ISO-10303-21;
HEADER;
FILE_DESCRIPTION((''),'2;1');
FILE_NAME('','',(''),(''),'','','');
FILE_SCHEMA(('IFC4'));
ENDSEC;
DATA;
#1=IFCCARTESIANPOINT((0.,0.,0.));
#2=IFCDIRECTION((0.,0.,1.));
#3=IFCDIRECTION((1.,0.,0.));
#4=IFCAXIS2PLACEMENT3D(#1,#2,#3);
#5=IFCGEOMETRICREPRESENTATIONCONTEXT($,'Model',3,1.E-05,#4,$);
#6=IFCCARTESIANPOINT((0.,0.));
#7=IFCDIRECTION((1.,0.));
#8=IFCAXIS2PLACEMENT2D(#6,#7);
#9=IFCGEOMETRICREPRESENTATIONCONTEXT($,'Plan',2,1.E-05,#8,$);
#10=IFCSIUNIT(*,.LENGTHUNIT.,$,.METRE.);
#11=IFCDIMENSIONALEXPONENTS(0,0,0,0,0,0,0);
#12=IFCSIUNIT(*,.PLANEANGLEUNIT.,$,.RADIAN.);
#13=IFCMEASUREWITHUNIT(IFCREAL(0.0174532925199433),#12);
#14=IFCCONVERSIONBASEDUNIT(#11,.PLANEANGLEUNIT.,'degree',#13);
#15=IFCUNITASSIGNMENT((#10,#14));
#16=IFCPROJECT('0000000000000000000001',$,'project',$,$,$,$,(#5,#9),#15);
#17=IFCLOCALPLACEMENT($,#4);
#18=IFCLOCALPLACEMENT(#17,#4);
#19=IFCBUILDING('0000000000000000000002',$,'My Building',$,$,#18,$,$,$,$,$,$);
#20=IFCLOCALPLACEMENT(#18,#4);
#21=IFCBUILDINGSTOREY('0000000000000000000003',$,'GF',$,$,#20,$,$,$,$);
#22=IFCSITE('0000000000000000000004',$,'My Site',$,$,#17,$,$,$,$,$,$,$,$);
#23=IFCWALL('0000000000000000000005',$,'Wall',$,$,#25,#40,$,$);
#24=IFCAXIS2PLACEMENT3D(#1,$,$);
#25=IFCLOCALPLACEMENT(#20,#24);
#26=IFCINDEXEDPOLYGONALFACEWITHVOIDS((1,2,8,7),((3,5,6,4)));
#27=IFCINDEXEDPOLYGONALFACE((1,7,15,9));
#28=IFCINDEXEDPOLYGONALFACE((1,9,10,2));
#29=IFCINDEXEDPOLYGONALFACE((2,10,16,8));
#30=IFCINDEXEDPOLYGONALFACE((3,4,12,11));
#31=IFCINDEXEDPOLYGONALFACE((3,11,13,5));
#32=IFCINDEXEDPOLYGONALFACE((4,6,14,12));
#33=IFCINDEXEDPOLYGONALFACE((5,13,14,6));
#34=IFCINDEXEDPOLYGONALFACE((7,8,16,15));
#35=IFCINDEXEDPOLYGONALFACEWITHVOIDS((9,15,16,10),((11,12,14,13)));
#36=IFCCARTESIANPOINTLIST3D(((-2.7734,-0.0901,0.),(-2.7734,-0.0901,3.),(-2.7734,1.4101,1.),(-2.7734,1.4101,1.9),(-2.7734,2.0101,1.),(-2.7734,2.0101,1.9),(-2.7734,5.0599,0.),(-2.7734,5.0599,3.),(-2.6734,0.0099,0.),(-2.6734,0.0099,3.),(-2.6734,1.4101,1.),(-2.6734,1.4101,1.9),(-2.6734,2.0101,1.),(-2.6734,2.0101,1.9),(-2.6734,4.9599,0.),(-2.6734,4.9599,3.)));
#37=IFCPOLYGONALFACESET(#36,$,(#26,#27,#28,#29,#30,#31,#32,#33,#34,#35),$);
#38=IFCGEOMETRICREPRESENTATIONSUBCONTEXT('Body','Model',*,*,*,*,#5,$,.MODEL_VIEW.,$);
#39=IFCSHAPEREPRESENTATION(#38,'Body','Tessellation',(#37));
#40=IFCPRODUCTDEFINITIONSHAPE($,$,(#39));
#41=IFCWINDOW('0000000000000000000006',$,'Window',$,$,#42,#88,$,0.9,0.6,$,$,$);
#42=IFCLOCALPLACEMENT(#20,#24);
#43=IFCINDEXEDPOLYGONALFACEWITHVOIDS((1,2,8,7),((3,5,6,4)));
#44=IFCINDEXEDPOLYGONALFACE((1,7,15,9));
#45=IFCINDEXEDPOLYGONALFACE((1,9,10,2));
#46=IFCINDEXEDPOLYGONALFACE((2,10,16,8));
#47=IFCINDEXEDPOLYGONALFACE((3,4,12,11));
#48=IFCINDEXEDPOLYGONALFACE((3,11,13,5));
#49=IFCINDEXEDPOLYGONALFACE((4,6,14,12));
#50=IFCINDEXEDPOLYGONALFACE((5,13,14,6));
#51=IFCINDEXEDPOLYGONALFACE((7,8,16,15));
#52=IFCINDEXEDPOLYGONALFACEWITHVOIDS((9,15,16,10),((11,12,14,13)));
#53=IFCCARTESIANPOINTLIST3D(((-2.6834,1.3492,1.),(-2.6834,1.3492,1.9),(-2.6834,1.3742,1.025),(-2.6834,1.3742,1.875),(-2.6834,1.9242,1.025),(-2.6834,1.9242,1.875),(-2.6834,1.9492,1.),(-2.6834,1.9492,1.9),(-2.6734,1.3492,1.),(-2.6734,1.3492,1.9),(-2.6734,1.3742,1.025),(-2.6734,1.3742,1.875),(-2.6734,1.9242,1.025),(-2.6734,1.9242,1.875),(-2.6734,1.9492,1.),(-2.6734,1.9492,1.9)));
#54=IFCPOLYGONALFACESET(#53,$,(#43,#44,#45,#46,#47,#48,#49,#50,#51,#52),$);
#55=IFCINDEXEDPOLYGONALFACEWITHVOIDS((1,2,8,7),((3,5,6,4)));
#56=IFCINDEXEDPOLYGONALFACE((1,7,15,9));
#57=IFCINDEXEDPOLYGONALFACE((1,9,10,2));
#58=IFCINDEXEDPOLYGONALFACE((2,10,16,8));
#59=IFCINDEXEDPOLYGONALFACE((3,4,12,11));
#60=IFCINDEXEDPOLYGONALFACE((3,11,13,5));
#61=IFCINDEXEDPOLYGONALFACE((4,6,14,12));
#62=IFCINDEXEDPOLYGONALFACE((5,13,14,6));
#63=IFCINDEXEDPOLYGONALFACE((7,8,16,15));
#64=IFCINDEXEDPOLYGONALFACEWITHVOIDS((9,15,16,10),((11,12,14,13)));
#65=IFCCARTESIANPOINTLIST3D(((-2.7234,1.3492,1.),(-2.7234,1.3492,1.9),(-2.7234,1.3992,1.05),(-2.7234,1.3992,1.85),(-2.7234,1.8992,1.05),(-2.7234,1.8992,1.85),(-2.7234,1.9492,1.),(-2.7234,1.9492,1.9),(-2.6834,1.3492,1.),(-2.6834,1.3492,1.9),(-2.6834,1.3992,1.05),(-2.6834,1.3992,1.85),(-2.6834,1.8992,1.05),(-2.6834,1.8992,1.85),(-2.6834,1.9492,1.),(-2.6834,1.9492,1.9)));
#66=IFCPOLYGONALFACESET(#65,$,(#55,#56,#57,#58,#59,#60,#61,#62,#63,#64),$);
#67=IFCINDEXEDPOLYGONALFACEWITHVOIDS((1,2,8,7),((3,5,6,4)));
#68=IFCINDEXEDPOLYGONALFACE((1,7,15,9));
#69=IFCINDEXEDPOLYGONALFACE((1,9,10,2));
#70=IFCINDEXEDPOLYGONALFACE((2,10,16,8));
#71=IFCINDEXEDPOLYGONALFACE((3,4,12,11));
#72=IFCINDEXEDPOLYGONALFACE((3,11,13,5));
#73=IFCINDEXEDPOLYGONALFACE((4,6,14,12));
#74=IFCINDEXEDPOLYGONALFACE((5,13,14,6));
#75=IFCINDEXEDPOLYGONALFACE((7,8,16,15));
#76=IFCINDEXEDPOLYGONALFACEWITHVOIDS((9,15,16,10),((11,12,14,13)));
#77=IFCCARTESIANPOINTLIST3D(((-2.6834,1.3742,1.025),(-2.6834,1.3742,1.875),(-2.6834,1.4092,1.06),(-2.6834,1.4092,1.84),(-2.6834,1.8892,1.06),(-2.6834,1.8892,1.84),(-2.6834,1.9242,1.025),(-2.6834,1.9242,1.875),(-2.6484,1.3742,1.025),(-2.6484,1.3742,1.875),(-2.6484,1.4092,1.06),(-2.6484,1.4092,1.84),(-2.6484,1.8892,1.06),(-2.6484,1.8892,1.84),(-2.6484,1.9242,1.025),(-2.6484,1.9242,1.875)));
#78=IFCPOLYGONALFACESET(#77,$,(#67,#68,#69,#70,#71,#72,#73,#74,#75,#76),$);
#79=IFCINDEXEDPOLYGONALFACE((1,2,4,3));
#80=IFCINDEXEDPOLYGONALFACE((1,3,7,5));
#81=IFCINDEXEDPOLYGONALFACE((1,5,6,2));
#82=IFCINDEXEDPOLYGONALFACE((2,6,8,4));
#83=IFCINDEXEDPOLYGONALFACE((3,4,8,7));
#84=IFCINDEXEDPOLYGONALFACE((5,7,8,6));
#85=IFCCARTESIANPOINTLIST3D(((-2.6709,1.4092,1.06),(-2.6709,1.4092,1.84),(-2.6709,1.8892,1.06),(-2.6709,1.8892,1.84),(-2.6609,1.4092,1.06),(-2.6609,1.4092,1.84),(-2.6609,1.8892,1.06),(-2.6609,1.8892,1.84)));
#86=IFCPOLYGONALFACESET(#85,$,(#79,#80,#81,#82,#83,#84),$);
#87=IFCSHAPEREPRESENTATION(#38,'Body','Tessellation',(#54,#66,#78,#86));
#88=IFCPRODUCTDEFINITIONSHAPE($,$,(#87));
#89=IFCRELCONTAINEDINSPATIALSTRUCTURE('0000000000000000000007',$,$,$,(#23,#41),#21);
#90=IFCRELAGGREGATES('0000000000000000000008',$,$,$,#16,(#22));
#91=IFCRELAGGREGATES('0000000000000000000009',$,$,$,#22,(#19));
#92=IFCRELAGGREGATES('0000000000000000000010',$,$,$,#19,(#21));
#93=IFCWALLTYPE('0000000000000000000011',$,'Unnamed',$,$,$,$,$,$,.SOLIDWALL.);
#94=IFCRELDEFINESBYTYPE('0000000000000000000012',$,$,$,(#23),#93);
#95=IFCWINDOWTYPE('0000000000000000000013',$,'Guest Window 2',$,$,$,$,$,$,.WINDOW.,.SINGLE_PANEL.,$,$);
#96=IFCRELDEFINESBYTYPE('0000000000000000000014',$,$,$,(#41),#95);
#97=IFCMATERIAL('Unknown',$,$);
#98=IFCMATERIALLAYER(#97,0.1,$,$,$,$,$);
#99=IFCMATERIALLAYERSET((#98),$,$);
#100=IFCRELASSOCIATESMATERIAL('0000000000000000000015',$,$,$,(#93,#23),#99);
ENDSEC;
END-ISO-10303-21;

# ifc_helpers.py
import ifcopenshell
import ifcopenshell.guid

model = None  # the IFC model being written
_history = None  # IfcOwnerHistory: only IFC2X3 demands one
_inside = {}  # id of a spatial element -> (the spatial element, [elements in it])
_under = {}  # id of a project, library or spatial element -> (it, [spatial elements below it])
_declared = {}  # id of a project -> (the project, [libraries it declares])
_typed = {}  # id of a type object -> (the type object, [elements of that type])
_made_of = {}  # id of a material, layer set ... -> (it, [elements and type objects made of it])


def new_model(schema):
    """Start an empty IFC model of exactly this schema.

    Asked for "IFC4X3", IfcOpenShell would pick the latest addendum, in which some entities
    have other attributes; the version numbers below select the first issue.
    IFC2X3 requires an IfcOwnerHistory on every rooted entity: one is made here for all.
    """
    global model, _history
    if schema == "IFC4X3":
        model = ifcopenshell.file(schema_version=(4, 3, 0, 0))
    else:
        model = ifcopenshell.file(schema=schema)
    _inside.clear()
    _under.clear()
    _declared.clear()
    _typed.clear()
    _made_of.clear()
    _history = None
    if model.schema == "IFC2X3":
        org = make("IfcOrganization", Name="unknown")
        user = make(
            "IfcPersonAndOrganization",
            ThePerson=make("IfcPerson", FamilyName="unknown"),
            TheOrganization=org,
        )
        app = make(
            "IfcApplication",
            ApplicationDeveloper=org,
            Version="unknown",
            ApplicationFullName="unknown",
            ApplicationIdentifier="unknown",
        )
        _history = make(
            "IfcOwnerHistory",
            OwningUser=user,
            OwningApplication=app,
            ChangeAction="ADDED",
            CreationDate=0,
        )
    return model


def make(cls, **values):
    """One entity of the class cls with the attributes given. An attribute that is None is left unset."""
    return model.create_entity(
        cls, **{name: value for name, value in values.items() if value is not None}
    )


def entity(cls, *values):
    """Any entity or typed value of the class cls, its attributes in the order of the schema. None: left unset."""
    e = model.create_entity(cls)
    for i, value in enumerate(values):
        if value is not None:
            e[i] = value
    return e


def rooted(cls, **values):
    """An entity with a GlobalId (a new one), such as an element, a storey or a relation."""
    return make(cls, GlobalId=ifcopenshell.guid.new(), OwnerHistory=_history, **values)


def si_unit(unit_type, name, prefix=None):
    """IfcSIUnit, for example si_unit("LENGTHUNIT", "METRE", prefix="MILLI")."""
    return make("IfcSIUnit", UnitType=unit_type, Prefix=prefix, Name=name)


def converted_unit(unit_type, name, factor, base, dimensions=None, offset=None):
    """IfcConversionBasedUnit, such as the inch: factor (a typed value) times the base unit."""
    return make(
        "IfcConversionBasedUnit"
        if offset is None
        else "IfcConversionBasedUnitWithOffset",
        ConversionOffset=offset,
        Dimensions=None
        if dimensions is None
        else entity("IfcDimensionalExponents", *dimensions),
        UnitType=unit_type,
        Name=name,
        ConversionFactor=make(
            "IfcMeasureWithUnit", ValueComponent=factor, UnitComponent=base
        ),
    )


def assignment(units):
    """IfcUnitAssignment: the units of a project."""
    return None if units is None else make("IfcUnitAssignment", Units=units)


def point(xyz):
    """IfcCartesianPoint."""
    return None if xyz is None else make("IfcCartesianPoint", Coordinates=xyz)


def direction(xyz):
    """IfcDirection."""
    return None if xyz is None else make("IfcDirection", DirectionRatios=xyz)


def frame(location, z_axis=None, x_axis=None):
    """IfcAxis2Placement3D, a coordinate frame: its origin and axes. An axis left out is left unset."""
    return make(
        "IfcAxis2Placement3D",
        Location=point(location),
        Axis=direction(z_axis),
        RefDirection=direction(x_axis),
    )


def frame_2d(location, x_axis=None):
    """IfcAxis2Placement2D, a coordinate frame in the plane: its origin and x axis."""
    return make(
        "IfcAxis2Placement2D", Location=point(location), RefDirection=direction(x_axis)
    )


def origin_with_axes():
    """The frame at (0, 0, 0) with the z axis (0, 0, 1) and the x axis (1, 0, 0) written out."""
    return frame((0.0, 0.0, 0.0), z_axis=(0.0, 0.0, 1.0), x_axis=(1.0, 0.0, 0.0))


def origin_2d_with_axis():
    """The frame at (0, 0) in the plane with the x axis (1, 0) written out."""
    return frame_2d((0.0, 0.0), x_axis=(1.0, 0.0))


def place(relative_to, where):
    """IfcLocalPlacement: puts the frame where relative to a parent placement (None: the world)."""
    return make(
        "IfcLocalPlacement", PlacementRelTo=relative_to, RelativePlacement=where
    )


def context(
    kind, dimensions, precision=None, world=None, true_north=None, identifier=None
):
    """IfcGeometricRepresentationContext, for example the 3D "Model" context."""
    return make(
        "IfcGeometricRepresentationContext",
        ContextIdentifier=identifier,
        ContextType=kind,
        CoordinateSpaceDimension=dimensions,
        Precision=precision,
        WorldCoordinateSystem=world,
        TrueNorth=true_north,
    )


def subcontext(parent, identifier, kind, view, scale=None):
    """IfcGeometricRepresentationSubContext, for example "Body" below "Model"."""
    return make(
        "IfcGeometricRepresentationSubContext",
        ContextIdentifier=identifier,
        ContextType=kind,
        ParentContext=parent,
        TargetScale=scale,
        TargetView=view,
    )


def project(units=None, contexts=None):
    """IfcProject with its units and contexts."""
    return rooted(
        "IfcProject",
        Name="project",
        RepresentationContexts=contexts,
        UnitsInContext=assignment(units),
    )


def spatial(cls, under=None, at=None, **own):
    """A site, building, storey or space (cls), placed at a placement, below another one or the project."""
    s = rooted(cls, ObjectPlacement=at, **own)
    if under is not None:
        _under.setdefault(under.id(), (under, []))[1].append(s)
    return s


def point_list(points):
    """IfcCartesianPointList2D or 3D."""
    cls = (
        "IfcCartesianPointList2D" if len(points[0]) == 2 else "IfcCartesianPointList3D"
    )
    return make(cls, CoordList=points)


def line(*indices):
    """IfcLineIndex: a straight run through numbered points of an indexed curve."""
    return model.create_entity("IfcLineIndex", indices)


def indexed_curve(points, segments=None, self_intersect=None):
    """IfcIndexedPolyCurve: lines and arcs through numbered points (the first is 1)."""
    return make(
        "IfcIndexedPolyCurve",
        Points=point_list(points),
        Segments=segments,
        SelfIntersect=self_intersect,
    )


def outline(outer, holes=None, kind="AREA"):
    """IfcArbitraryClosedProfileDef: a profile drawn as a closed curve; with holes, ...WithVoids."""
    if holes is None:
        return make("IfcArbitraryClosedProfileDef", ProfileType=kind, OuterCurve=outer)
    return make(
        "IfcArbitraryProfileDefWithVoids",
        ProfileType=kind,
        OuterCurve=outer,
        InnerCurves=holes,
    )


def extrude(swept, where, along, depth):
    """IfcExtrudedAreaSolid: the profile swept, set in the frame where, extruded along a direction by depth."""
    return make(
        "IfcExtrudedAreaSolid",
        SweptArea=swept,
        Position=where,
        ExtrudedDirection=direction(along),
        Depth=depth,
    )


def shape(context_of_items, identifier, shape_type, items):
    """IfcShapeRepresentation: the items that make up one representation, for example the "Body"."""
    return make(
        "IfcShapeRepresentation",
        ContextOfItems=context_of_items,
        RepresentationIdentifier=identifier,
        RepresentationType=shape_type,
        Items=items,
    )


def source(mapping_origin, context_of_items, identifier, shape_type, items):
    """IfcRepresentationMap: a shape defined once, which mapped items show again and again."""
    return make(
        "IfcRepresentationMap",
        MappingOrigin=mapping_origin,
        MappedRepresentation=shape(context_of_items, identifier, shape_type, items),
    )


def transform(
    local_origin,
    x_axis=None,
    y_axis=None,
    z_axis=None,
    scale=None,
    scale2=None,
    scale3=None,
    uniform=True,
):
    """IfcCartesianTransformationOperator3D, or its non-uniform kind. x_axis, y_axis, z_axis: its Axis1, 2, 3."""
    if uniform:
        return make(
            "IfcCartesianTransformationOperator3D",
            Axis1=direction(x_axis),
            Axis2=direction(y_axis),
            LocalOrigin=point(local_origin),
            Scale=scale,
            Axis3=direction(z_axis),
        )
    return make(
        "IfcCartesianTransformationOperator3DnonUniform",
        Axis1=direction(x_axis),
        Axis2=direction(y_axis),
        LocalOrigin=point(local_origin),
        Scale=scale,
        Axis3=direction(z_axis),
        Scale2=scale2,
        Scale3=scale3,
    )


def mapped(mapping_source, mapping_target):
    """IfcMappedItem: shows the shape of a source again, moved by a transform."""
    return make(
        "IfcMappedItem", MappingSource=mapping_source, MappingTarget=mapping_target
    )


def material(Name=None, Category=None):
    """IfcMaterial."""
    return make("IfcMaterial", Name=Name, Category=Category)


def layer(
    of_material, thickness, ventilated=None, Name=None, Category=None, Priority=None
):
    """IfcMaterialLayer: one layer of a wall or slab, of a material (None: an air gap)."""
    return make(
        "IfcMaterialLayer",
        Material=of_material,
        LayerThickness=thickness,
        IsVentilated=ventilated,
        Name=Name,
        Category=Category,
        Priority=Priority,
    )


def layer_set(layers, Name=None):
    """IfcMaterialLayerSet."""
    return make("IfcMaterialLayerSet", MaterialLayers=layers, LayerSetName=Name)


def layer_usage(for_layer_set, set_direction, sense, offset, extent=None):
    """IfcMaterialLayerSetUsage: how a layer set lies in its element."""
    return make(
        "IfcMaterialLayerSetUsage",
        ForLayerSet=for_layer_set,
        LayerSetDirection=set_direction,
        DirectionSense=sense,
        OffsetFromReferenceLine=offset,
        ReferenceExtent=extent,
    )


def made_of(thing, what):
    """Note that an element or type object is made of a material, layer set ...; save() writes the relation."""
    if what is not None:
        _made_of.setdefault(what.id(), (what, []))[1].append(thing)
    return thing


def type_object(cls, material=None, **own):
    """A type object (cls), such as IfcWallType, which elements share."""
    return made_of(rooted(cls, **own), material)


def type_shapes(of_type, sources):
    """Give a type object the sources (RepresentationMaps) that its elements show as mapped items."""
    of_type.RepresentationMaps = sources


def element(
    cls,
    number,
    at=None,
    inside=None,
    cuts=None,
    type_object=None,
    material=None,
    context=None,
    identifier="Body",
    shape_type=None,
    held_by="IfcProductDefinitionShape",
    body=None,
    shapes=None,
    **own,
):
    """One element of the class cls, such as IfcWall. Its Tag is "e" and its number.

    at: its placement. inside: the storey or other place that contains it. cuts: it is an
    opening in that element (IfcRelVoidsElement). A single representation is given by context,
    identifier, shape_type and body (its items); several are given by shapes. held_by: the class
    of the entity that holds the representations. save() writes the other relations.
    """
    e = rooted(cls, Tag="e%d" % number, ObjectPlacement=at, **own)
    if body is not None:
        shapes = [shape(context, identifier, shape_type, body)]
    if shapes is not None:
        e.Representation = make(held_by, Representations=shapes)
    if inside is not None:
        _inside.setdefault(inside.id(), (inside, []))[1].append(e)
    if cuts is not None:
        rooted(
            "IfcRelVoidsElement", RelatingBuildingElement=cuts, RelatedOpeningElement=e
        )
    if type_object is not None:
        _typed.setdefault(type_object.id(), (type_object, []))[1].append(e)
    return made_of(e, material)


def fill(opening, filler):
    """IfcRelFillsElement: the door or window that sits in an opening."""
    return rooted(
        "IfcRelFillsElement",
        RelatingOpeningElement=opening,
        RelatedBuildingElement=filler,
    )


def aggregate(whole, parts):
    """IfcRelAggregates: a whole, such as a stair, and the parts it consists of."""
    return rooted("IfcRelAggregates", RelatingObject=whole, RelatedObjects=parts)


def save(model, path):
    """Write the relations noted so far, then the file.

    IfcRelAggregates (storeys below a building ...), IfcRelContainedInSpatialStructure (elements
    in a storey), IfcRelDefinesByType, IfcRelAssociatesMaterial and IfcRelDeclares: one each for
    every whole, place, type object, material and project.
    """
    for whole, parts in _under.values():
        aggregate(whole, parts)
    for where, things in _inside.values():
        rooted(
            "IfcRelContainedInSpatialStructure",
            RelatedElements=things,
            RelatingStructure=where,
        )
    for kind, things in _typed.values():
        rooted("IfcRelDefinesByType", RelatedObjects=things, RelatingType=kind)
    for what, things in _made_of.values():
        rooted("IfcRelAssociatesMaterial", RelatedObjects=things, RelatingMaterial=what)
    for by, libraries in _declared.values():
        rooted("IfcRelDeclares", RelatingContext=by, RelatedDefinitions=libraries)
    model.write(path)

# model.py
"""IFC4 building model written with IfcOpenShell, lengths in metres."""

from ifc_helpers import new_model, entity, si_unit, converted_unit, frame, origin_with_axes, origin_2d_with_axis, place, context, subcontext, project, spatial, line, indexed_curve, outline, extrude, shape, source, transform, mapped, material, layer, layer_set, layer_usage, type_object, type_shapes, element, fill, save


model = new_model("IFC4")

# Units and contexts
model_context = context("Model", 3, precision=1e-05, world=origin_with_axes())
plan_context = context("Plan", 2, precision=1e-05, world=origin_2d_with_axis())
body_context_1 = subcontext(model_context, "Body", "Model", "MODEL_VIEW")
body_context_2 = subcontext(plan_context, "Body", "Plan", "PLAN_VIEW")
ifc_project = project(units=[si_unit("LENGTHUNIT", "METRE"), converted_unit("PLANEANGLEUNIT", "degree", entity("IfcReal", 0.0174532925199433), si_unit("PLANEANGLEUNIT", "RADIAN"), dimensions=[0, 0, 0, 0, 0, 0, 0])], contexts=[model_context, plan_context])

# Site, building, storey
site_placement = place(None, origin_with_axes())
site = spatial("IfcSite", under=ifc_project, at=site_placement, Name="My Site")
building_placement = place(site_placement, origin_with_axes())
building = spatial("IfcBuilding", under=site, at=building_placement, Name="My Building")
storey_placement = place(building_placement, origin_with_axes())
storey = spatial("IfcBuildingStorey", under=building, at=storey_placement, Name="GF")

# Shared definitions
ifc_material = material(Name="Unknown")

# Shared definitions
ifc_layer_1 = layer(ifc_material, 0.1)
ifc_layer_set_1 = layer_set([ifc_layer_1])
wall_type = type_object("IfcWallType", Name="Unnamed", PredefinedType="SOLIDWALL", material=ifc_layer_set_1)

# Wall, opening, window
ifc_layer_usage_1 = layer_usage(ifc_layer_set_1, "AXIS2", "POSITIVE", 0.0)
wall_1_placement = place(storey_placement, frame((-2.7734, 5.0599, 0.0), z_axis=(0.0, 0.0, 1.0), x_axis=(0.0, -1.0, 0.0)))
wall_1 = element("IfcWall", 1, at=wall_1_placement, inside=storey, type_object=wall_type, material=ifc_layer_usage_1, Name="Wall", context=body_context_1, shape_type="SweptSolid", body=[
    extrude(outline(indexed_curve([(0.0, 0.0), (0.1, 0.1), (5.05, 0.1), (5.15, 0.0)], segments=[line(1, 2, 3, 4, 1)])), origin_with_axes(), (0.0, 0.0, 1.0), 3.0),
])
shared_shape_1 = source(origin_with_axes(), body_context_1, "Body", "SweptSolid", [
    extrude(outline(indexed_curve([(0.0, 0.0), (0.6, 0.0), (0.6, 0.9), (0.0, 0.9)], segments=[line(1, 2, 3, 4, 1)])), frame((0.0, -0.6, 0.0), z_axis=(0.0, -1.0, 0.0), x_axis=(1.0, 0.0, 0.0)), (0.0, 0.0, -1.0), 1.2),
])
opening_1_placement = place(wall_1_placement, frame((3.0498, 0.0, 1.0), z_axis=(0.0, 0.0, 1.0), x_axis=(1.0, 0.0, 0.0)))
opening_1 = element("IfcOpeningElement", 2, at=opening_1_placement, cuts=wall_1, PredefinedType="OPENING", context=body_context_1, shape_type="MappedRepresentation", body=[
    mapped(shared_shape_1, transform((0.0, 0.0, 0.0), x_axis=(1.0, 0.0, 0.0), y_axis=(0.0, 1.0, 0.0), z_axis=(0.0, 0.0, 1.0), scale=1.0)),
])
window_type_1 = type_object("IfcWindowType", Name="Guest Window 2", PartitioningType="SINGLE_PANEL", PredefinedType="WINDOW")
shared_shape_2 = source(origin_with_axes(), body_context_1, "Body", "SweptSolid", [
    extrude(outline(indexed_curve([(0.0, 0.0), (0.6, 0.0), (0.6, 0.9), (0.0, 0.9)], segments=[line(1, 2, 3, 4, 1)]), holes=[indexed_curve([(0.025, 0.025), (0.575, 0.025), (0.575, 0.875), (0.025, 0.875)], segments=[line(1, 2, 3, 4, 1)])]), frame((0.0, 0.09, 0.0), z_axis=(0.0, -1.0, 0.0), x_axis=(1.0, 0.0, 0.0)), (0.0, 0.0, -1.0), 0.01),
    extrude(outline(indexed_curve([(0.0, 0.0), (0.6, 0.0), (0.6, 0.9), (0.0, 0.9)], segments=[line(1, 2, 3, 4, 1)]), holes=[indexed_curve([(0.05, 0.05), (0.55, 0.05), (0.55, 0.85), (0.05, 0.85)], segments=[line(1, 2, 3, 4, 1)])]), frame((0.0, 0.05, 0.0), z_axis=(0.0, -1.0, 0.0), x_axis=(1.0, 0.0, 0.0)), (0.0, 0.0, -1.0), 0.04),
    extrude(outline(indexed_curve([(0.0, 0.0), (0.55, 0.0), (0.55, 0.85), (0.0, 0.85)], segments=[line(1, 2, 3, 4, 1)]), holes=[indexed_curve([(0.035, 0.035), (0.515, 0.035), (0.515, 0.815), (0.035, 0.815)], segments=[line(1, 2, 3, 4, 1)])]), frame((0.025, 0.09, 0.025), z_axis=(0.0, -1.0, 0.0), x_axis=(1.0, 0.0, 0.0)), (0.0, 0.0, -1.0), 0.035),
    extrude(outline(indexed_curve([(0.035, 0.035), (0.515, 0.035), (0.515, 0.815), (0.035, 0.815)], segments=[line(1, 2, 3, 4, 1)])), frame((0.025, 0.1025, 0.025), z_axis=(0.0, -1.0, 0.0), x_axis=(1.0, 0.0, 0.0)), (0.0, 0.0, -1.0), 0.01),
])
shared_shape_3 = source(origin_with_axes(), body_context_2, "Body", "Curve2D", [
    entity("IfcIndexedPolyCurve", entity("IfcCartesianPointList2D", [[0.05, 0.05], [0.55, 0.05]])),
    entity("IfcIndexedPolyCurve", entity("IfcCartesianPointList2D", [[0.0, 0.1], [0.025, 0.1], [0.025, 0.09], [0.05, 0.09], [0.05, 0.05], [0.0, 0.05]]), [entity("IfcLineIndex", [1, 2, 3, 4, 5, 6, 1])]),
    entity("IfcIndexedPolyCurve", entity("IfcCartesianPointList2D", [[0.6, 0.1], [0.575, 0.1], [0.575, 0.09], [0.55, 0.09], [0.55, 0.05], [0.6, 0.05]]), [entity("IfcLineIndex", [1, 2, 3, 4, 5, 6, 1])]),
    entity("IfcIndexedPolyCurve", entity("IfcCartesianPointList2D", [[0.025, 0.09], [0.06, 0.09], [0.06, 0.125], [0.025, 0.125]]), [entity("IfcLineIndex", [1, 2, 3, 4, 1])]),
    entity("IfcIndexedPolyCurve", entity("IfcCartesianPointList2D", [[0.575, 0.09], [0.54, 0.09], [0.54, 0.125], [0.575, 0.125]]), [entity("IfcLineIndex", [1, 2, 3, 4, 1])]),
    entity("IfcIndexedPolyCurve", entity("IfcCartesianPointList2D", [[0.06, 0.09], [0.54, 0.09]])),
    entity("IfcIndexedPolyCurve", entity("IfcCartesianPointList2D", [[0.06, 0.125], [0.54, 0.125]])),
    entity("IfcIndexedPolyCurve", entity("IfcCartesianPointList2D", [[0.06, 0.1075], [0.54, 0.1075]])),
])
type_shapes(window_type_1, [shared_shape_2, shared_shape_3])
window_1_placement = place(opening_1_placement, frame((0.061, 0.0, 0.0), z_axis=(0.0, 0.0, 1.0), x_axis=(1.0, 0.0, 0.0)))
window_1 = element("IfcWindow", 3, at=window_1_placement, inside=storey, type_object=window_type_1, Name="Window", OverallHeight=0.9, OverallWidth=0.6, shapes=[
    shape(body_context_1, "Body", "MappedRepresentation", [mapped(shared_shape_2, transform((0.0, 0.0, 0.0), x_axis=(1.0, 0.0, 0.0), y_axis=(0.0, 1.0, 0.0), z_axis=(0.0, 0.0, 1.0), scale=1.0))]),
    shape(body_context_2, "Body", "MappedRepresentation", [mapped(shared_shape_3, transform((0.0, 0.0, 0.0), x_axis=(1.0, 0.0, 0.0), y_axis=(0.0, 1.0, 0.0), z_axis=(0.0, 0.0, 1.0), scale=1.0))]),
])
fill(opening_1, window_1)

save(model, "model.ifc")
